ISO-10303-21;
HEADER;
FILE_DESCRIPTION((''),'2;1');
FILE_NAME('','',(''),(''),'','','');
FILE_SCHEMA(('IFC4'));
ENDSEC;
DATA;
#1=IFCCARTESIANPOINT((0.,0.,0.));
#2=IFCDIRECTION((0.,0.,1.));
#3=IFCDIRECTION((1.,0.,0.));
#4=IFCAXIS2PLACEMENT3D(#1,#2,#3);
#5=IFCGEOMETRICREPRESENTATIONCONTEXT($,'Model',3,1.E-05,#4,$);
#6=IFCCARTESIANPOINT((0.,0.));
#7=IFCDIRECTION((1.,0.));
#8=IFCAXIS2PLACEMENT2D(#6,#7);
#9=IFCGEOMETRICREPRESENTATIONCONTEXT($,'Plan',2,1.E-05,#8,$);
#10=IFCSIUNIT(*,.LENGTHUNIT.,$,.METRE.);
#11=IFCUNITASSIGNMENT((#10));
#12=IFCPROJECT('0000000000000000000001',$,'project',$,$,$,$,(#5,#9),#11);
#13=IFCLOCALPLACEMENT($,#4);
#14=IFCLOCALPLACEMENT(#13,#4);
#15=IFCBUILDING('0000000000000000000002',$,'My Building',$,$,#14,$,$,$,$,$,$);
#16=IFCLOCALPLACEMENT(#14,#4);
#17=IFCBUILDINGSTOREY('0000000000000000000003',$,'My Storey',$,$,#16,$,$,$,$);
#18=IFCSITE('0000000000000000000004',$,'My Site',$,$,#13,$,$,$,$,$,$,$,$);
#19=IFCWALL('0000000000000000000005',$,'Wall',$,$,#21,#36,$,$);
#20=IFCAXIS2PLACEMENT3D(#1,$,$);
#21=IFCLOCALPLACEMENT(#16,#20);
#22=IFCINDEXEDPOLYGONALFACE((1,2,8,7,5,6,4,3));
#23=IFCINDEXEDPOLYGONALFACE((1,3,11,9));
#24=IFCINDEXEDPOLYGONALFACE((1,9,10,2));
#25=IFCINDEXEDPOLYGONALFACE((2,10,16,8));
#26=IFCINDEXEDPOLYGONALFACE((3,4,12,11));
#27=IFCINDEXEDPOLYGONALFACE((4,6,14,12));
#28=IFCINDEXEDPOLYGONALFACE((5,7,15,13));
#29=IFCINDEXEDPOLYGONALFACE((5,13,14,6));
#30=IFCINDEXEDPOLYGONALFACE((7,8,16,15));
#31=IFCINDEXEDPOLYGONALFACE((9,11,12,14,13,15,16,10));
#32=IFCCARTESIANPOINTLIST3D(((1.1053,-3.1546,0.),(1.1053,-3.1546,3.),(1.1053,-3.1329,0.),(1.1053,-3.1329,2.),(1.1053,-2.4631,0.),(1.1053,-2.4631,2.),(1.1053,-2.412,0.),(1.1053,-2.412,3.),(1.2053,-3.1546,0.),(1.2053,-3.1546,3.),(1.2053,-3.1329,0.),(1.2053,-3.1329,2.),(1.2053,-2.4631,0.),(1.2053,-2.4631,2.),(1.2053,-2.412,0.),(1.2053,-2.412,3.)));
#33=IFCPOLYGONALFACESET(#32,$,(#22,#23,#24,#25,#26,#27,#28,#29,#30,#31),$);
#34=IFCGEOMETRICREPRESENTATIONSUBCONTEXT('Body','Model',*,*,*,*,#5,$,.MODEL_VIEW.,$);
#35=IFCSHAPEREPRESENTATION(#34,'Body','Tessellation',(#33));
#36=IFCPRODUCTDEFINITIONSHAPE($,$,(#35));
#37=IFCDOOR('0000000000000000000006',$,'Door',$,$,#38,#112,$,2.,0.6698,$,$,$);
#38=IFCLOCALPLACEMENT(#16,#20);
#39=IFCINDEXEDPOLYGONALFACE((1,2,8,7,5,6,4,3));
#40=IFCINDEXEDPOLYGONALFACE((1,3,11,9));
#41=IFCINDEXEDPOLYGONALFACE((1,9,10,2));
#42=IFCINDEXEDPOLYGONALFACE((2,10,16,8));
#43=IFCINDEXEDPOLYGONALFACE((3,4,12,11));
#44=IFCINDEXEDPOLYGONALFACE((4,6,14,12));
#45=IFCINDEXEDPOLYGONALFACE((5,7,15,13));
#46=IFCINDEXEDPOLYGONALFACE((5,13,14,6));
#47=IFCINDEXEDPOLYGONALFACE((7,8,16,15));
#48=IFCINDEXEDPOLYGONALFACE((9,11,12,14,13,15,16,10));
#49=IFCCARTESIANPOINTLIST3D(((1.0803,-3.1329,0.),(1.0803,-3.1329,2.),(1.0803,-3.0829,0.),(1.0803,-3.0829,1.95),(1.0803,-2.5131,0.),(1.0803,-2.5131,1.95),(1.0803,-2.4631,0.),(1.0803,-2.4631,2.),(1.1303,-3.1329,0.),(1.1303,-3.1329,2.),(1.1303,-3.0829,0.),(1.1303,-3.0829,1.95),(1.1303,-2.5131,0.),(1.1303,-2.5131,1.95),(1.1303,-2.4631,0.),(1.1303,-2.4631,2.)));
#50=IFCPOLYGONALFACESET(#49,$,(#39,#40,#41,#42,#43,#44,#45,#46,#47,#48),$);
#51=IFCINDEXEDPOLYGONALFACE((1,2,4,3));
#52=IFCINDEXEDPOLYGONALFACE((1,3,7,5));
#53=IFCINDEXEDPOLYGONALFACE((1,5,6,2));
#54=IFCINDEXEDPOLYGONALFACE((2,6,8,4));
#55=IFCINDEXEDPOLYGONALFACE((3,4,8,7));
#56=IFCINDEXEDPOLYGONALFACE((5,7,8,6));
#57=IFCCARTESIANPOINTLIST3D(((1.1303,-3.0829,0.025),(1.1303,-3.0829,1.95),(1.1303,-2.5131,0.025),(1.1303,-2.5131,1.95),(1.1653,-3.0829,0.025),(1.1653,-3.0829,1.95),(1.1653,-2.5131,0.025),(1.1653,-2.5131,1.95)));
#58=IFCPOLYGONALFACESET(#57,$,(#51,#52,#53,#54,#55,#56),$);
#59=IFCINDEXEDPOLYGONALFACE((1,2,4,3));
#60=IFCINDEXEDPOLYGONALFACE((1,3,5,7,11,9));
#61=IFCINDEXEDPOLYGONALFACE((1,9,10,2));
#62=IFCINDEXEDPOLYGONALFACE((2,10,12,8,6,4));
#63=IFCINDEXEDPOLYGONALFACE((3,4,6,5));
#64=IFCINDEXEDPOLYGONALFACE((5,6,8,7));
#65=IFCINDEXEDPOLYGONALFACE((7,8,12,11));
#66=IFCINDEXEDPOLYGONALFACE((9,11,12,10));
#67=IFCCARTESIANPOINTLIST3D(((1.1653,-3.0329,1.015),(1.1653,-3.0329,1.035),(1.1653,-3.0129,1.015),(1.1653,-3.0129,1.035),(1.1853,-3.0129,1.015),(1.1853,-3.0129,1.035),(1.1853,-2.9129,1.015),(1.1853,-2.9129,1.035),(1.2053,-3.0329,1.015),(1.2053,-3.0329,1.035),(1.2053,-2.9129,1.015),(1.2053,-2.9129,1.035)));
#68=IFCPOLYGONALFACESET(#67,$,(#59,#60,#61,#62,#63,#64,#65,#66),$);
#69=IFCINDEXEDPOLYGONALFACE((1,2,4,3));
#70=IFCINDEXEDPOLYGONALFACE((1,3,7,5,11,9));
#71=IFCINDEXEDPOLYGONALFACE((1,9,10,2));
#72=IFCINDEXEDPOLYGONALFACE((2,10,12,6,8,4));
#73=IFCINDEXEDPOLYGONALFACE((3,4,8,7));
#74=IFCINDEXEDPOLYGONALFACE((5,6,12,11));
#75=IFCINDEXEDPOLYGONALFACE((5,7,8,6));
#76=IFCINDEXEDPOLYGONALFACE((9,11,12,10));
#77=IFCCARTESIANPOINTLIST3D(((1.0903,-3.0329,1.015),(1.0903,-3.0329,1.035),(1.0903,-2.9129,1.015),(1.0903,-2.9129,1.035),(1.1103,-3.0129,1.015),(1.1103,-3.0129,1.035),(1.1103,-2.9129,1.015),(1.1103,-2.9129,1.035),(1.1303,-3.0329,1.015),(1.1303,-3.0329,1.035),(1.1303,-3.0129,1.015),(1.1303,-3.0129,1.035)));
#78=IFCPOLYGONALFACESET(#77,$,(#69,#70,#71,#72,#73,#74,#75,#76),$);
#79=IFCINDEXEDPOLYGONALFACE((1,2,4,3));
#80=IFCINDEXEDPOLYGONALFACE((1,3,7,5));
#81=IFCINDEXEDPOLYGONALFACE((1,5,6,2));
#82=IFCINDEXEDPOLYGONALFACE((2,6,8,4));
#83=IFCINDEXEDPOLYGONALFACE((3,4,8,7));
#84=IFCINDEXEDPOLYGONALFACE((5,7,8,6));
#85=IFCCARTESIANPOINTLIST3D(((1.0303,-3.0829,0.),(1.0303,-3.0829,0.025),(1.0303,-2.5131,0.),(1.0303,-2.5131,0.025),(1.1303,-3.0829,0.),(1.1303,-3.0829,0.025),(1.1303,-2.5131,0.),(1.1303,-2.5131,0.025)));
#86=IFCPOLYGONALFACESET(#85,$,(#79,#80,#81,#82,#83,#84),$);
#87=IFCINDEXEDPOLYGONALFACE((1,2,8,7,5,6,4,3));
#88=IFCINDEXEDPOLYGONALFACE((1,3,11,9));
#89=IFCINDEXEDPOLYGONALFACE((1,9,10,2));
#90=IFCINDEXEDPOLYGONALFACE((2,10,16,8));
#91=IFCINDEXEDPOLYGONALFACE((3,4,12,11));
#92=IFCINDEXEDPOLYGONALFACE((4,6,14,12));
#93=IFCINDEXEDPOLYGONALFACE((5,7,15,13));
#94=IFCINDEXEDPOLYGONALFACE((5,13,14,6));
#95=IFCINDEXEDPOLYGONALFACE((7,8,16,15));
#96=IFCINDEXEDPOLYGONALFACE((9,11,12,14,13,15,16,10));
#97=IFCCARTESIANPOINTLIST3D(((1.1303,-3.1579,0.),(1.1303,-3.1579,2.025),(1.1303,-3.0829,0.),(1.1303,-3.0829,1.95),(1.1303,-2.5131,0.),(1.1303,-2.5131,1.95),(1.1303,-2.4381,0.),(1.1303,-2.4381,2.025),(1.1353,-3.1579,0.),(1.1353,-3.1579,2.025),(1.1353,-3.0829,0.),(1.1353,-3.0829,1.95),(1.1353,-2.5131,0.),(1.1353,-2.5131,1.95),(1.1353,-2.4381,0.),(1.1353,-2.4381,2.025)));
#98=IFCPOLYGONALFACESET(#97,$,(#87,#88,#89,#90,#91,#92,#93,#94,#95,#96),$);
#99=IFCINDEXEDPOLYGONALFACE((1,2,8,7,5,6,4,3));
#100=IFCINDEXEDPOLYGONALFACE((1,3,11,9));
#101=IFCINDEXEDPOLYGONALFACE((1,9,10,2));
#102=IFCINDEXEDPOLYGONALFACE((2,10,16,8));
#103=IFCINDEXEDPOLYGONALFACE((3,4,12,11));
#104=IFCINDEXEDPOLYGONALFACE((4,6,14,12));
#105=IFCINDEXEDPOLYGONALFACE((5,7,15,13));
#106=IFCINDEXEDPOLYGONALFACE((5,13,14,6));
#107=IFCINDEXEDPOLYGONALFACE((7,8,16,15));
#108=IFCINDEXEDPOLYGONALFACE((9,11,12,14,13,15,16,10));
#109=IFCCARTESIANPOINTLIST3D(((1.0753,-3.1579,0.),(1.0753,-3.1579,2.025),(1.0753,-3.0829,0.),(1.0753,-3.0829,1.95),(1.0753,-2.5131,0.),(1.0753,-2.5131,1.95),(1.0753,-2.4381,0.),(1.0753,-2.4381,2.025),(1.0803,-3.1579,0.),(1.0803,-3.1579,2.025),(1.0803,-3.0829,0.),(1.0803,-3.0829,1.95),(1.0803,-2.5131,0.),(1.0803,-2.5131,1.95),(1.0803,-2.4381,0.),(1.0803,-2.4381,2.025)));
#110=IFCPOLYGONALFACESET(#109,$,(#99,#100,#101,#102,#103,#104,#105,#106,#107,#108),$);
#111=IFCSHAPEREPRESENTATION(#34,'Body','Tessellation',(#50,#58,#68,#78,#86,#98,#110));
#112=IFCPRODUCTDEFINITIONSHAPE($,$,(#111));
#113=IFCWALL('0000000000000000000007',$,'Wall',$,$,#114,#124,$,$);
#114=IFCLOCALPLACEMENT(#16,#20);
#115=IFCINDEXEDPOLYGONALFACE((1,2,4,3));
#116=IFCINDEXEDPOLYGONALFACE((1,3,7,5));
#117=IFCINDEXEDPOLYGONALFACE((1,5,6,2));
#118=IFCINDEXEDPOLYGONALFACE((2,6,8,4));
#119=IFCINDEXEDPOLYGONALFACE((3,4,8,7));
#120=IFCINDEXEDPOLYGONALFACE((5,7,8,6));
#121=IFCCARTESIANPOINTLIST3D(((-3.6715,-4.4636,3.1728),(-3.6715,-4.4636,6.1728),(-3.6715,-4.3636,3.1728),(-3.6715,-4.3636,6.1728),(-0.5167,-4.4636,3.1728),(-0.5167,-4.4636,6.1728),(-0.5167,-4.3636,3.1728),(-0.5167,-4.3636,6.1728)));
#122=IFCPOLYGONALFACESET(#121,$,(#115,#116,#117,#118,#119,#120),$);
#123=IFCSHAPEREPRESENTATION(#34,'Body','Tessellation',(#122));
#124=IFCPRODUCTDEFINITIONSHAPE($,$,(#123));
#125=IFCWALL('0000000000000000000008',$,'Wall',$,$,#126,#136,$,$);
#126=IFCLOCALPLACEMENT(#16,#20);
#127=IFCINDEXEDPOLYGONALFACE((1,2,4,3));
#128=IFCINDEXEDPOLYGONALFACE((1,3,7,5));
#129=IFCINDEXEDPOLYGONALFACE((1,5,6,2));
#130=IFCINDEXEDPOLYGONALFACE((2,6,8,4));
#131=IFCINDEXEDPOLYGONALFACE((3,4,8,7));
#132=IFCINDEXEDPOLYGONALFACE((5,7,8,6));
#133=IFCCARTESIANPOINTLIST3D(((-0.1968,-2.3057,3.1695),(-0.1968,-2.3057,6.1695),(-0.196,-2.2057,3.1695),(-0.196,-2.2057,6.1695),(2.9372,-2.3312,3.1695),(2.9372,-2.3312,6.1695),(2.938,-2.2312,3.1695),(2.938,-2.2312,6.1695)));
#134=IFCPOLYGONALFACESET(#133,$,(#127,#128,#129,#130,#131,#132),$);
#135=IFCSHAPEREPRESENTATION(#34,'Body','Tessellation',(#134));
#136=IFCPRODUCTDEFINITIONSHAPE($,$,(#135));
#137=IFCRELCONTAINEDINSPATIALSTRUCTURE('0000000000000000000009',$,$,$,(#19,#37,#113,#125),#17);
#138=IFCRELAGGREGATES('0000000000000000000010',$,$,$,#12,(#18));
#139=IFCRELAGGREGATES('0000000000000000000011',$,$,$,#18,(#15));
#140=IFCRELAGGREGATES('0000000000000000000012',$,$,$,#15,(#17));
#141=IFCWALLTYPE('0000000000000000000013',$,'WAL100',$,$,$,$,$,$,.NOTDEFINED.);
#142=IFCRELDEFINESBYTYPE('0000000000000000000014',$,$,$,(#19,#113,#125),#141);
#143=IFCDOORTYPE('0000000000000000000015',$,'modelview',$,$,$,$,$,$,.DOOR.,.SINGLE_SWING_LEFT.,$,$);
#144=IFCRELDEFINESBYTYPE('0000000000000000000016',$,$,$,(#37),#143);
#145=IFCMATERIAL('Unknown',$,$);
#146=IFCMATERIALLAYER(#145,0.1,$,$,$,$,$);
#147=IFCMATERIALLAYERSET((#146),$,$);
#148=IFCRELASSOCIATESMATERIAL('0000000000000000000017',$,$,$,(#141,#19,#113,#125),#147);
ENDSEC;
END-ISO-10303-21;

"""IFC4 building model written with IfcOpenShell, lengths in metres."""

from ifc_helpers import new_model, entity, si_unit, frame, origin_with_axes, origin_2d_with_axis, place, context, subcontext, project, spatial, line, indexed_curve, outline, extrude, shape, source, transform, mapped, material, layer, layer_set, layer_usage, type_object, type_shapes, element, fill, save


model = new_model("IFC4")

# Units and contexts
model_context = context("Model", 3, precision=1e-05, world=origin_with_axes())
plan_context = context("Plan", 2, precision=1e-05, world=origin_2d_with_axis())
body_context_1 = subcontext(model_context, "Body", "Model", "MODEL_VIEW")
body_context_2 = subcontext(plan_context, "Body", "Plan", "PLAN_VIEW")
ifc_project = project(units=[si_unit("LENGTHUNIT", "METRE")], contexts=[model_context, plan_context])

# Site, building, storey
site_placement = place(None, origin_with_axes())
site = spatial("IfcSite", under=ifc_project, at=site_placement, Name="My Site")
building_placement = place(site_placement, origin_with_axes())
building = spatial("IfcBuilding", under=site, at=building_placement, Name="My Building")
storey_placement = place(building_placement, origin_with_axes())
storey = spatial("IfcBuildingStorey", under=building, at=storey_placement, Name="My Storey")

# Shared definitions
ifc_material = material(Name="Unknown")
ifc_layer_1 = layer(ifc_material, 0.1)
ifc_layer_set_1 = layer_set([ifc_layer_1])
wall_type_1 = type_object("IfcWallType", Name="WAL100", PredefinedType="NOTDEFINED", material=ifc_layer_set_1)

# Wall, opening, door
shared_shape_1 = source(origin_with_axes(), body_context_1, "Body", "SweptSolid", [
    extrude(outline(indexed_curve([(0.0, 0.0), (0.6698, 0.0), (0.6698, 2.0), (0.0, 2.0)], segments=[line(1, 2, 3, 4, 1)])), frame((0.0, -0.6, 0.0), z_axis=(0.0, -1.0, 0.0), x_axis=(1.0, 0.0, 0.0)), (0.0, 0.0, -1.0), 1.2),
])
door_type_1 = type_object("IfcDoorType", Name="modelview", OperationType="SINGLE_SWING_LEFT", PredefinedType="DOOR")
shared_shape_2 = source(origin_with_axes(), body_context_1, "Body", "SweptSolid", [
    extrude(outline(indexed_curve([(0.0, 0.0), (0.0, 2.0), (0.6698, 2.0), (0.6698, 0.0), (0.6198, 0.0), (0.6198, 1.95), (0.05, 1.95), (0.05, 0.0)], segments=[line(1, 2, 3, 4, 5, 6, 7, 8, 1)])), frame((0.0, 0.0, 0.0), z_axis=(0.0, -1.0, 0.0), x_axis=(1.0, 0.0, 0.0)), (0.0, 0.0, -1.0), 0.05),
    extrude(outline(indexed_curve([(0.0, 0.0), (0.5698, 0.0), (0.5698, 0.035), (0.0, 0.035)], segments=[line(1, 2, 3, 4, 1)])), frame((0.05, -0.035, 0.025), z_axis=(0.0, 0.0, 1.0), x_axis=(1.0, 0.0, 0.0)), (0.0, 0.0, 1.0), 1.925),
    extrude(outline(indexed_curve([(0.0, 0.0), (0.0, -0.04), (0.12, -0.04), (0.12, -0.02), (0.02, -0.02), (0.02, 0.0)], segments=[line(1, 2, 3, 4, 5, 6, 1)])), frame((0.1, -0.035, 1.015), z_axis=(0.0, 0.0, 1.0), x_axis=(1.0, 0.0, 0.0)), (0.0, 0.0, 1.0), 0.02),
    extrude(outline(indexed_curve([(0.0, 0.0), (0.0, 0.04), (0.12, 0.04), (0.12, 0.02), (0.02, 0.02), (0.02, 0.0)], segments=[line(1, 2, 3, 4, 5, 6, 1)])), frame((0.1, 0.0, 1.015), z_axis=(0.0, 0.0, 1.0), x_axis=(1.0, 0.0, 0.0)), (0.0, 0.0, 1.0), 0.02),
    extrude(outline(indexed_curve([(0.0, 0.0), (0.5698, 0.0), (0.5698, 0.1), (0.0, 0.1)], segments=[line(1, 2, 3, 4, 1)])), frame((0.05, 0.0, 0.0), z_axis=(0.0, 0.0, 1.0), x_axis=(1.0, 0.0, 0.0)), (0.0, 0.0, 1.0), 0.025),
    extrude(outline(indexed_curve([(0.0, 0.0), (0.0, 2.025), (0.7198, 2.025), (0.7198, 0.0), (0.6448, 0.0), (0.6448, 1.95), (0.075, 1.95), (0.075, 0.0)], segments=[line(1, 2, 3, 4, 5, 6, 7, 8, 1)])), frame((-0.025, -0.005, 0.0), z_axis=(0.0, -1.0, 0.0), x_axis=(1.0, 0.0, 0.0)), (0.0, 0.0, -1.0), 0.005),
    extrude(outline(indexed_curve([(0.0, 0.0), (0.0, 2.025), (0.7198, 2.025), (0.7198, 0.0), (0.6448, 0.0), (0.6448, 1.95), (0.075, 1.95), (0.075, 0.0)], segments=[line(1, 2, 3, 4, 5, 6, 7, 8, 1)])), frame((-0.025, 0.05, 0.0), z_axis=(0.0, -1.0, 0.0), x_axis=(1.0, 0.0, 0.0)), (0.0, 0.0, -1.0), 0.005),
])
shared_shape_3 = source(origin_with_axes(), body_context_2, "Body", "Curve2D", [
    entity("IfcIndexedPolyCurve", entity("IfcCartesianPointList2D", [[0.0, 0.0], [0.05, 0.0], [0.05, 0.05], [0.0, 0.05]]), [entity("IfcLineIndex", [1, 2, 3, 4, 1])]),
    entity("IfcIndexedPolyCurve", entity("IfcCartesianPointList2D", [[0.6698, 0.0], [0.6198, 0.0], [0.6198, 0.05], [0.6698, 0.05]]), [entity("IfcLineIndex", [1, 2, 3, 4, 1])]),
    entity("IfcIndexedPolyCurve", entity("IfcCartesianPointList2D", [[0.9047, -0.035], [0.3349, -0.035], [0.3349, 0.0], [0.9047, 0.0]]), [entity("IfcLineIndex", [1, 2, 3, 4, 1])]),
])
type_shapes(door_type_1, [shared_shape_2, shared_shape_3])
ifc_layer_usage_1 = layer_usage(ifc_layer_set_1, "AXIS2", "POSITIVE", 0.0)
wall_1_placement = place(storey_placement, frame((1.2053, -3.1546, 0.0), z_axis=(0.0, 0.0, 1.0), x_axis=(0.0, 1.0, 0.0)))
wall_1 = element("IfcWall", 1, at=wall_1_placement, inside=storey, type_object=wall_type_1, material=ifc_layer_usage_1, Name="Wall", context=body_context_1, shape_type="SweptSolid", body=[
    extrude(outline(indexed_curve([(0.0, 0.0), (0.0, 0.1), (0.7426, 0.1), (0.7426, 0.0)], segments=[line(1, 2, 3, 4, 1)])), origin_with_axes(), (0.0, 0.0, 1.0), 3.0),
])
opening_1_placement = place(wall_1_placement, frame((0.0217, 0.075, 0.0), z_axis=(0.0, 0.0, 1.0), x_axis=(1.0, 0.0, 0.0)))
opening_1 = element("IfcOpeningElement", 2, at=opening_1_placement, cuts=wall_1, PredefinedType="OPENING", context=body_context_1, shape_type="MappedRepresentation", body=[
    mapped(shared_shape_1, transform((0.0, 0.0, 0.0), x_axis=(1.0, 0.0, 0.0), y_axis=(0.0, 1.0, 0.0), z_axis=(0.0, 0.0, 1.0), scale=1.0)),
])
door_1_placement = place(opening_1_placement, frame((0.0, 0.0, 0.0), z_axis=(0.0, 0.0, 1.0), x_axis=(1.0, 0.0, 0.0)))
door_1 = element("IfcDoor", 3, at=door_1_placement, inside=storey, type_object=door_type_1, Name="Door", OverallHeight=2.0, OverallWidth=0.6698, shapes=[
    shape(body_context_1, "Body", "MappedRepresentation", [mapped(shared_shape_2, transform((0.0, 0.0, 0.0), x_axis=(1.0, 0.0, 0.0), y_axis=(0.0, 1.0, 0.0), z_axis=(0.0, 0.0, 1.0), scale=1.0))]),
    shape(body_context_2, "Body", "MappedRepresentation", [mapped(shared_shape_3, transform((0.0, 0.0, 0.0), x_axis=(1.0, 0.0, 0.0), y_axis=(0.0, 1.0, 0.0), z_axis=(0.0, 0.0, 1.0), scale=1.0))]),
])
fill(opening_1, door_1)

# Walls
ifc_layer_usage_2 = layer_usage(ifc_layer_set_1, "AXIS2", "POSITIVE", 0.0)
wall_2_placement = place(storey_placement, frame((-3.6715, -4.4636, 3.1728), z_axis=(0.0, 0.0, 1.0), x_axis=(1.0, 0.0, 0.0)))
element("IfcWall", 4, at=wall_2_placement, inside=storey, type_object=wall_type_1, material=ifc_layer_usage_2, Name="Wall", context=body_context_1, shape_type="SweptSolid", body=[
    extrude(outline(indexed_curve([(0.0, 0.0), (0.0, 0.1), (3.1548, 0.1), (3.1548, 0.0)], segments=[line(1, 2, 3, 4, 1)])), origin_with_axes(), (0.0, 0.0, 1.0), 3.0),
])
ifc_layer_usage_3 = layer_usage(ifc_layer_set_1, "AXIS2", "POSITIVE", 0.0)
wall_3_placement = place(storey_placement, frame((-0.1968, -2.3057, 3.1695), z_axis=(0.0, 0.0, 1.0), x_axis=(0.999967, -0.008116, 0.0)))
element("IfcWall", 5, at=wall_3_placement, inside=storey, type_object=wall_type_1, material=ifc_layer_usage_3, Name="Wall", context=body_context_1, shape_type="SweptSolid", body=[
    extrude(outline(indexed_curve([(0.0, 0.0), (0.0, 0.1), (3.1341, 0.1), (3.1341, 0.0)], segments=[line(1, 2, 3, 4, 1)])), origin_with_axes(), (0.0, 0.0, 1.0), 3.0),
])

save(model, "model.ifc")
